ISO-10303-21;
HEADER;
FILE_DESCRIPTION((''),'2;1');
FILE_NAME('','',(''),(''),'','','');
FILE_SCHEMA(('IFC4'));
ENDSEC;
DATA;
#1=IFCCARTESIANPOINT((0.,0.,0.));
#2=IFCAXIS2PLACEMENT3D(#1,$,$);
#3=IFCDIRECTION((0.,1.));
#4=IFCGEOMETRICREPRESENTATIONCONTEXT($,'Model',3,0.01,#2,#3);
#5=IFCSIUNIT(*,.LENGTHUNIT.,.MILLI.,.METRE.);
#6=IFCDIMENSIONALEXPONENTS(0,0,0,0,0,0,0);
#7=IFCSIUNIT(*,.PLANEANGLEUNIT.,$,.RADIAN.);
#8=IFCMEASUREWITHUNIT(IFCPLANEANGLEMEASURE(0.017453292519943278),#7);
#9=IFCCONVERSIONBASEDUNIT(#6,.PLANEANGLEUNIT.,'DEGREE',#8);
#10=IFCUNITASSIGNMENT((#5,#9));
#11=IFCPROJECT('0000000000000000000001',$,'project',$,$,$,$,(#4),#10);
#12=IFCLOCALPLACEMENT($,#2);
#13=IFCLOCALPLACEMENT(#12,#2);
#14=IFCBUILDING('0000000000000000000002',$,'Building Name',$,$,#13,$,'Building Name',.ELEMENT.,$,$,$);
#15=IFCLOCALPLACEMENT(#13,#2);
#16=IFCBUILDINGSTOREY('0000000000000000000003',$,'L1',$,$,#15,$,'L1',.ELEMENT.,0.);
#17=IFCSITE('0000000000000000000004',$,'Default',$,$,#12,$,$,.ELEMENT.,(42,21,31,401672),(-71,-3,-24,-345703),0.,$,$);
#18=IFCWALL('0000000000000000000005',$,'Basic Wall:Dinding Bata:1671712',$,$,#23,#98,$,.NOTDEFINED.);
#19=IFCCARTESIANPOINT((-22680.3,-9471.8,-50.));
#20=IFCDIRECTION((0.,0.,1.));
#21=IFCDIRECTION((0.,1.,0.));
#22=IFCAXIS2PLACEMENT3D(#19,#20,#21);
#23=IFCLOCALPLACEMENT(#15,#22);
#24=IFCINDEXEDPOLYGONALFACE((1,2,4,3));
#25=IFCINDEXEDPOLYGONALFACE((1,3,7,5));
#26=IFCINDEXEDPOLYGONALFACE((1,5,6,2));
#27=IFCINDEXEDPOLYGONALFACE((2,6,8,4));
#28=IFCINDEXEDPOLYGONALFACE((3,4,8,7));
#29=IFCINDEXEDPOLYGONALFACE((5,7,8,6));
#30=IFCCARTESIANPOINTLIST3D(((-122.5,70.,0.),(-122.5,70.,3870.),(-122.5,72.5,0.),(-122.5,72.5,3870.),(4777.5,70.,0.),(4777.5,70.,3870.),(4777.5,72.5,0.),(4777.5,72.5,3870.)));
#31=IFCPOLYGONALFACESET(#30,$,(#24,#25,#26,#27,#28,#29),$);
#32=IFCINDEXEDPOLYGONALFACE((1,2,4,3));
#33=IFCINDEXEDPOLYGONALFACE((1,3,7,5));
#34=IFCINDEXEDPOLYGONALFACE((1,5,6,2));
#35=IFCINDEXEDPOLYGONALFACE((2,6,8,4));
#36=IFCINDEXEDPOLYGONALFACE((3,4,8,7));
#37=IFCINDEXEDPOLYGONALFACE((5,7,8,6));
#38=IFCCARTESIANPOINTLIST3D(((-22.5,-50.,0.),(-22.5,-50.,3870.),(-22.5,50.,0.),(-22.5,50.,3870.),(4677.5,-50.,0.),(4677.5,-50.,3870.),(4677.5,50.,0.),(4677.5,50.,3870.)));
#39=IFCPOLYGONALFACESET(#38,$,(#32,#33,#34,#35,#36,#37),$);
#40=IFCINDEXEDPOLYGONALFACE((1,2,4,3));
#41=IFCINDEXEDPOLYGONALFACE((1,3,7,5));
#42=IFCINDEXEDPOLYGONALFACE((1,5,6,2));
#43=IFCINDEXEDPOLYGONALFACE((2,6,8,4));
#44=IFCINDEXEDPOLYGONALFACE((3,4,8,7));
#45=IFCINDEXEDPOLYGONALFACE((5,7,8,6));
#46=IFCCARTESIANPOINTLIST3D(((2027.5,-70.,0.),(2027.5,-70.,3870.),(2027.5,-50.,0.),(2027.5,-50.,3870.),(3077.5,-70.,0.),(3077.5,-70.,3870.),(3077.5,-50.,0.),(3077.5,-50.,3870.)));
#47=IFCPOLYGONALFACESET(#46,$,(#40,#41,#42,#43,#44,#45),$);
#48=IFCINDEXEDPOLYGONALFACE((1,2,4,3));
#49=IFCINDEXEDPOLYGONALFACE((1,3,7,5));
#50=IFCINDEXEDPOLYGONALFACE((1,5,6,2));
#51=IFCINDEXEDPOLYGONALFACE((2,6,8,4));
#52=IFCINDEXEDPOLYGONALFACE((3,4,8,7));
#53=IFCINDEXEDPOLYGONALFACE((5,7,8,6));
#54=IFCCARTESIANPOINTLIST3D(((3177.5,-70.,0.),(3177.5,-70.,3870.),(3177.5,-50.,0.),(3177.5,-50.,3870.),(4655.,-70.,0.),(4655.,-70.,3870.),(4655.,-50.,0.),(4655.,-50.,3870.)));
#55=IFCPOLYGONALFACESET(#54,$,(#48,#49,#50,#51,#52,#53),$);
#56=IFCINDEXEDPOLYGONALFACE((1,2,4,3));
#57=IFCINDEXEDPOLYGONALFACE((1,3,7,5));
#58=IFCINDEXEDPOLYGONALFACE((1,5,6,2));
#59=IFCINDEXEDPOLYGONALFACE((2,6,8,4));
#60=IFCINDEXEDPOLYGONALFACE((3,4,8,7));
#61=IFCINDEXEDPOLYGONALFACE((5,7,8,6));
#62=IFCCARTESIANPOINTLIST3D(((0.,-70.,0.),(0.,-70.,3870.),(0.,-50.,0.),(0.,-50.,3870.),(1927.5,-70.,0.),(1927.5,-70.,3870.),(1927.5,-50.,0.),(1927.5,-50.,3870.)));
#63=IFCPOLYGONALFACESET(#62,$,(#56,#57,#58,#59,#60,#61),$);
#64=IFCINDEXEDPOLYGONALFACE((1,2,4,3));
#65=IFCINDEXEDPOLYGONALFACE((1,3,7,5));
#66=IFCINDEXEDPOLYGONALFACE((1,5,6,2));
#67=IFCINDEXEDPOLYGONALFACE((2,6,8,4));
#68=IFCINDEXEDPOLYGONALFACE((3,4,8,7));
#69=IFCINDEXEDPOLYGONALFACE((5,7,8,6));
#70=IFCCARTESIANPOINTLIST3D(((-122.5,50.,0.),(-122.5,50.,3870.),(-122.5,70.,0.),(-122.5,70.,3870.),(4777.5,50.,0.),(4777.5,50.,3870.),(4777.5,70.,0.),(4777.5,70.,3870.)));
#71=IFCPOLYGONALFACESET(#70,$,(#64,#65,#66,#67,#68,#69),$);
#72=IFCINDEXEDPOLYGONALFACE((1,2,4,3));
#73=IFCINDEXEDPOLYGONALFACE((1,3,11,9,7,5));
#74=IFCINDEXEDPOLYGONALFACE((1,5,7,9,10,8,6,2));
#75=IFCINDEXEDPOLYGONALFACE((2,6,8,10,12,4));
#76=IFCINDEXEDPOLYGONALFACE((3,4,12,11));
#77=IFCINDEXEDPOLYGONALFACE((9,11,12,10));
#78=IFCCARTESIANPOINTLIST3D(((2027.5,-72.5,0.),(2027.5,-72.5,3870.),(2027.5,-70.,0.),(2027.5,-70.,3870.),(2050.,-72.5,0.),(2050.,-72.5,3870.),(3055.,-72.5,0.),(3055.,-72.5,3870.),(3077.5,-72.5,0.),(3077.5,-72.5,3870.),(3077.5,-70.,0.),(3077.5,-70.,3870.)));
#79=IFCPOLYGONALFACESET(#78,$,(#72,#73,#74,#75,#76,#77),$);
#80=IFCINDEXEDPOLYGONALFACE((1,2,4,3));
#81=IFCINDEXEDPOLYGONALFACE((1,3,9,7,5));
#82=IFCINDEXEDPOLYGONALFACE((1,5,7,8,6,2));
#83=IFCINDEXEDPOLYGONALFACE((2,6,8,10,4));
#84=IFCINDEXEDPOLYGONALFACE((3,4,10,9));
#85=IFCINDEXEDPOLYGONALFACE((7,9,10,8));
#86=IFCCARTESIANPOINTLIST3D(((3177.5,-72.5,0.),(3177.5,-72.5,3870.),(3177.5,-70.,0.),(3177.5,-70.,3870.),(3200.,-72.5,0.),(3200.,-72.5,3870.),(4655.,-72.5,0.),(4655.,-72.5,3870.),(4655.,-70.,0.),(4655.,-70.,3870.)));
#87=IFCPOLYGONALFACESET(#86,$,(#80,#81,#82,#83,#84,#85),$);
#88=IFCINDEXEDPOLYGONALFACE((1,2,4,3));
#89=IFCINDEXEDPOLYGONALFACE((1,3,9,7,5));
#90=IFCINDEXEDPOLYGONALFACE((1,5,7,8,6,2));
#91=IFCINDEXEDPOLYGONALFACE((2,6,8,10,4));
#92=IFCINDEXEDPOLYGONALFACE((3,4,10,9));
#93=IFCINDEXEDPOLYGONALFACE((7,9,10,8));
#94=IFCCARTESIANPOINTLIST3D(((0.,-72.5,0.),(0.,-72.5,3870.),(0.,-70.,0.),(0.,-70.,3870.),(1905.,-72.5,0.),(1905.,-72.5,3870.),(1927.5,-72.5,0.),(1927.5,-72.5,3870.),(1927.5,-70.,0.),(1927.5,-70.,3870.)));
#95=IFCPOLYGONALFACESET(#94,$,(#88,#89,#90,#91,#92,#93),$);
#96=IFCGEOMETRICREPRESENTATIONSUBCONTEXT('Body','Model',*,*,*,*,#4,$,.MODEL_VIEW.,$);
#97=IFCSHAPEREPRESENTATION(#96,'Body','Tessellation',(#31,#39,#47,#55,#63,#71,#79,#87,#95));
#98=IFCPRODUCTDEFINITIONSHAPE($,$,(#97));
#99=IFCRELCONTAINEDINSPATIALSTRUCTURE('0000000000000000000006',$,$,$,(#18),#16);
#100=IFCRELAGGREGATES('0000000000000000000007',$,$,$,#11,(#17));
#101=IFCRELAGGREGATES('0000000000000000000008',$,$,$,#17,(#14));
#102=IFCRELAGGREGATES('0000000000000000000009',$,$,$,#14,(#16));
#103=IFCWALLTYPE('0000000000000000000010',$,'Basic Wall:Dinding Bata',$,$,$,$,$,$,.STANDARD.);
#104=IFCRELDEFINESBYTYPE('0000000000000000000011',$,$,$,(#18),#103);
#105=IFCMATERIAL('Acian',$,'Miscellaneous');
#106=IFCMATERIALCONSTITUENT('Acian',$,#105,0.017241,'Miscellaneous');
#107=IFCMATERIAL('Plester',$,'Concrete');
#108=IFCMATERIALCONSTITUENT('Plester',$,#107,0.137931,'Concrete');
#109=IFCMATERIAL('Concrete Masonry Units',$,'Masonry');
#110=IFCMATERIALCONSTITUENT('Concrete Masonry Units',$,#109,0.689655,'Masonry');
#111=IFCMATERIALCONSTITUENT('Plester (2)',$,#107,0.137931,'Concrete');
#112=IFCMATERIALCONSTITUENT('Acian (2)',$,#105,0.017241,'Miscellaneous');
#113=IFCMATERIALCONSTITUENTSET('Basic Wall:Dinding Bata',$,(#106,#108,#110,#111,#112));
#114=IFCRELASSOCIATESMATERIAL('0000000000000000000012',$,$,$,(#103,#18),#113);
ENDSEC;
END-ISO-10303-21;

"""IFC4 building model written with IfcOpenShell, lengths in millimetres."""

from ifc_helpers import new_model, entity, si_unit, converted_unit, direction, frame, origin, place, context, subcontext, project, spatial, indexed_curve, outline, extrude, material, constituent, constituent_set, type_object, element, save


model = new_model("IFC4")

# Units and contexts
model_context = context("Model", 3, precision=0.01, world=origin(), true_north=direction((0.0, 1.0)))
body_context = subcontext(model_context, "Body", "Model", "MODEL_VIEW")
ifc_project = project(units=[si_unit("LENGTHUNIT", "METRE", prefix="MILLI"), converted_unit("PLANEANGLEUNIT", "DEGREE", entity("IfcPlaneAngleMeasure", 0.017453292519943278), si_unit("PLANEANGLEUNIT", "RADIAN"), dimensions=[0, 0, 0, 0, 0, 0, 0])], contexts=[model_context])

# Site, building, storey
site_placement = place(None, origin())
site = spatial("IfcSite", under=ifc_project, at=site_placement, Name="Default", CompositionType="ELEMENT", RefLatitude=(42, 21, 31, 401672), RefLongitude=(-71, -3, -24, -345703), RefElevation=0.0)
building_placement = place(site_placement, origin())
building = spatial("IfcBuilding", under=site, at=building_placement, Name="Building Name", LongName="Building Name", CompositionType="ELEMENT")
storey_placement = place(building_placement, origin())
storey = spatial("IfcBuildingStorey", under=building, at=storey_placement, Name="L1", LongName="L1", CompositionType="ELEMENT", Elevation=0.0)

# Wall
ifc_material_1 = material(Name="Acian", Category="Miscellaneous")
ifc_constituent_1 = constituent(ifc_material_1, Name="Acian", Category="Miscellaneous", fraction=0.017241)
ifc_material_2 = material(Name="Plester", Category="Concrete")
ifc_constituent_2 = constituent(ifc_material_2, Name="Plester", Category="Concrete", fraction=0.137931)
ifc_material_3 = material(Name="Concrete Masonry Units", Category="Masonry")
ifc_constituent_3 = constituent(ifc_material_3, Name="Concrete Masonry Units", Category="Masonry", fraction=0.689655)
ifc_constituent_4 = constituent(ifc_material_2, Name="Plester (2)", Category="Concrete", fraction=0.137931)
ifc_constituent_5 = constituent(ifc_material_1, Name="Acian (2)", Category="Miscellaneous", fraction=0.017241)
ifc_constituent_set = constituent_set(constituents=[ifc_constituent_1, ifc_constituent_2, ifc_constituent_3, ifc_constituent_4, ifc_constituent_5], Name="Basic Wall:Dinding Bata")
wall_type = type_object("IfcWallType", Name="Basic Wall:Dinding Bata", PredefinedType="STANDARD", material=ifc_constituent_set)
wall_1_placement = place(storey_placement, frame((-22680.3, -9471.8, -50.0), z_axis=(0.0, 0.0, 1.0), x_axis=(0.0, 1.0, 0.0)))
element("IfcWall", 1, at=wall_1_placement, inside=storey, type_object=wall_type, material=ifc_constituent_set, Name="Basic Wall:Dinding Bata:1671712", PredefinedType="NOTDEFINED", context=body_context, shape_type="SweptSolid", body=[
    extrude(outline(indexed_curve([(-1.3, -2450.0), (1.2, -2450.0), (1.3, 2450.0), (-1.2, 2450.0), (-1.3, -2450.0)], self_intersect=False)), frame((2327.5, 71.3, 0.0), z_axis=(0.0, 0.0, 1.0), x_axis=(0.0, -1.0, 0.0)), (0.0, 0.0, 1.0), 3870.0),
    extrude(outline(indexed_curve([(-2350.0, -50.0), (2350.0, -50.0), (2350.0, 50.0), (-2350.0, 50.0), (-2350.0, -50.0)], self_intersect=False)), frame((2327.5, 0.0, 0.0)), (0.0, 0.0, 1.0), 3870.0),
    extrude(outline(indexed_curve([(-525.0, -10.0), (525.0, -10.0), (525.0, 10.0), (-525.0, 10.0), (-525.0, -10.0)], self_intersect=False)), frame((2552.5, -60.0, 0.0)), (0.0, 0.0, 1.0), 3870.0),
    extrude(outline(indexed_curve([(-738.7, -10.0), (738.7, -10.0), (738.7, 10.0), (-738.7, 10.0), (-738.7, -10.0)], self_intersect=False)), frame((3916.2, -60.0, 0.0), z_axis=(0.0, 0.0, 1.0), x_axis=(-1.0, 0.0, 0.0)), (0.0, 0.0, 1.0), 3870.0),
    extrude(outline(indexed_curve([(-963.8, -10.0), (963.8, -10.0), (963.8, 10.0), (-963.8, 10.0), (-963.8, -10.0)], self_intersect=False)), frame((963.8, -60.0, 0.0)), (0.0, 0.0, 1.0), 3870.0),
    extrude(outline(indexed_curve([(-2450.0, -10.0), (2450.0, -10.0), (2450.0, 10.0), (-2450.0, 10.0), (-2450.0, -10.0)], self_intersect=False)), frame((2327.5, 60.0, 0.0)), (0.0, 0.0, 1.0), 3870.0),
    extrude(outline(indexed_curve([(502.5, -0.8), (525.0, -0.8), (525.0, 1.7), (-525.0, 1.7), (-525.0, -0.8), (-502.5, -0.8), (502.5, -0.8)], self_intersect=False)), frame((2552.5, -71.7, 0.0)), (0.0, 0.0, 1.0), 3870.0),
    extrude(outline(indexed_curve([(-1.0, -882.0), (1.5, -882.0), (1.5, 595.5), (-1.0, 595.5), (-1.0, 573.0), (-1.0, -882.0)], self_intersect=False)), frame((3773.0, -71.5, 0.0), z_axis=(0.0, 0.0, 1.0), x_axis=(0.0, 1.0, 0.0)), (0.0, 0.0, 1.0), 3870.0),
    extrude(outline(indexed_curve([(753.0, -1.0), (775.5, -1.0), (775.5, 1.5), (-1152.0, 1.5), (-1152.0, -1.0), (753.0, -1.0)], self_intersect=False)), frame((1152.0, -71.5, 0.0)), (0.0, 0.0, 1.0), 3870.0),
])

save(model, "model.ifc")
